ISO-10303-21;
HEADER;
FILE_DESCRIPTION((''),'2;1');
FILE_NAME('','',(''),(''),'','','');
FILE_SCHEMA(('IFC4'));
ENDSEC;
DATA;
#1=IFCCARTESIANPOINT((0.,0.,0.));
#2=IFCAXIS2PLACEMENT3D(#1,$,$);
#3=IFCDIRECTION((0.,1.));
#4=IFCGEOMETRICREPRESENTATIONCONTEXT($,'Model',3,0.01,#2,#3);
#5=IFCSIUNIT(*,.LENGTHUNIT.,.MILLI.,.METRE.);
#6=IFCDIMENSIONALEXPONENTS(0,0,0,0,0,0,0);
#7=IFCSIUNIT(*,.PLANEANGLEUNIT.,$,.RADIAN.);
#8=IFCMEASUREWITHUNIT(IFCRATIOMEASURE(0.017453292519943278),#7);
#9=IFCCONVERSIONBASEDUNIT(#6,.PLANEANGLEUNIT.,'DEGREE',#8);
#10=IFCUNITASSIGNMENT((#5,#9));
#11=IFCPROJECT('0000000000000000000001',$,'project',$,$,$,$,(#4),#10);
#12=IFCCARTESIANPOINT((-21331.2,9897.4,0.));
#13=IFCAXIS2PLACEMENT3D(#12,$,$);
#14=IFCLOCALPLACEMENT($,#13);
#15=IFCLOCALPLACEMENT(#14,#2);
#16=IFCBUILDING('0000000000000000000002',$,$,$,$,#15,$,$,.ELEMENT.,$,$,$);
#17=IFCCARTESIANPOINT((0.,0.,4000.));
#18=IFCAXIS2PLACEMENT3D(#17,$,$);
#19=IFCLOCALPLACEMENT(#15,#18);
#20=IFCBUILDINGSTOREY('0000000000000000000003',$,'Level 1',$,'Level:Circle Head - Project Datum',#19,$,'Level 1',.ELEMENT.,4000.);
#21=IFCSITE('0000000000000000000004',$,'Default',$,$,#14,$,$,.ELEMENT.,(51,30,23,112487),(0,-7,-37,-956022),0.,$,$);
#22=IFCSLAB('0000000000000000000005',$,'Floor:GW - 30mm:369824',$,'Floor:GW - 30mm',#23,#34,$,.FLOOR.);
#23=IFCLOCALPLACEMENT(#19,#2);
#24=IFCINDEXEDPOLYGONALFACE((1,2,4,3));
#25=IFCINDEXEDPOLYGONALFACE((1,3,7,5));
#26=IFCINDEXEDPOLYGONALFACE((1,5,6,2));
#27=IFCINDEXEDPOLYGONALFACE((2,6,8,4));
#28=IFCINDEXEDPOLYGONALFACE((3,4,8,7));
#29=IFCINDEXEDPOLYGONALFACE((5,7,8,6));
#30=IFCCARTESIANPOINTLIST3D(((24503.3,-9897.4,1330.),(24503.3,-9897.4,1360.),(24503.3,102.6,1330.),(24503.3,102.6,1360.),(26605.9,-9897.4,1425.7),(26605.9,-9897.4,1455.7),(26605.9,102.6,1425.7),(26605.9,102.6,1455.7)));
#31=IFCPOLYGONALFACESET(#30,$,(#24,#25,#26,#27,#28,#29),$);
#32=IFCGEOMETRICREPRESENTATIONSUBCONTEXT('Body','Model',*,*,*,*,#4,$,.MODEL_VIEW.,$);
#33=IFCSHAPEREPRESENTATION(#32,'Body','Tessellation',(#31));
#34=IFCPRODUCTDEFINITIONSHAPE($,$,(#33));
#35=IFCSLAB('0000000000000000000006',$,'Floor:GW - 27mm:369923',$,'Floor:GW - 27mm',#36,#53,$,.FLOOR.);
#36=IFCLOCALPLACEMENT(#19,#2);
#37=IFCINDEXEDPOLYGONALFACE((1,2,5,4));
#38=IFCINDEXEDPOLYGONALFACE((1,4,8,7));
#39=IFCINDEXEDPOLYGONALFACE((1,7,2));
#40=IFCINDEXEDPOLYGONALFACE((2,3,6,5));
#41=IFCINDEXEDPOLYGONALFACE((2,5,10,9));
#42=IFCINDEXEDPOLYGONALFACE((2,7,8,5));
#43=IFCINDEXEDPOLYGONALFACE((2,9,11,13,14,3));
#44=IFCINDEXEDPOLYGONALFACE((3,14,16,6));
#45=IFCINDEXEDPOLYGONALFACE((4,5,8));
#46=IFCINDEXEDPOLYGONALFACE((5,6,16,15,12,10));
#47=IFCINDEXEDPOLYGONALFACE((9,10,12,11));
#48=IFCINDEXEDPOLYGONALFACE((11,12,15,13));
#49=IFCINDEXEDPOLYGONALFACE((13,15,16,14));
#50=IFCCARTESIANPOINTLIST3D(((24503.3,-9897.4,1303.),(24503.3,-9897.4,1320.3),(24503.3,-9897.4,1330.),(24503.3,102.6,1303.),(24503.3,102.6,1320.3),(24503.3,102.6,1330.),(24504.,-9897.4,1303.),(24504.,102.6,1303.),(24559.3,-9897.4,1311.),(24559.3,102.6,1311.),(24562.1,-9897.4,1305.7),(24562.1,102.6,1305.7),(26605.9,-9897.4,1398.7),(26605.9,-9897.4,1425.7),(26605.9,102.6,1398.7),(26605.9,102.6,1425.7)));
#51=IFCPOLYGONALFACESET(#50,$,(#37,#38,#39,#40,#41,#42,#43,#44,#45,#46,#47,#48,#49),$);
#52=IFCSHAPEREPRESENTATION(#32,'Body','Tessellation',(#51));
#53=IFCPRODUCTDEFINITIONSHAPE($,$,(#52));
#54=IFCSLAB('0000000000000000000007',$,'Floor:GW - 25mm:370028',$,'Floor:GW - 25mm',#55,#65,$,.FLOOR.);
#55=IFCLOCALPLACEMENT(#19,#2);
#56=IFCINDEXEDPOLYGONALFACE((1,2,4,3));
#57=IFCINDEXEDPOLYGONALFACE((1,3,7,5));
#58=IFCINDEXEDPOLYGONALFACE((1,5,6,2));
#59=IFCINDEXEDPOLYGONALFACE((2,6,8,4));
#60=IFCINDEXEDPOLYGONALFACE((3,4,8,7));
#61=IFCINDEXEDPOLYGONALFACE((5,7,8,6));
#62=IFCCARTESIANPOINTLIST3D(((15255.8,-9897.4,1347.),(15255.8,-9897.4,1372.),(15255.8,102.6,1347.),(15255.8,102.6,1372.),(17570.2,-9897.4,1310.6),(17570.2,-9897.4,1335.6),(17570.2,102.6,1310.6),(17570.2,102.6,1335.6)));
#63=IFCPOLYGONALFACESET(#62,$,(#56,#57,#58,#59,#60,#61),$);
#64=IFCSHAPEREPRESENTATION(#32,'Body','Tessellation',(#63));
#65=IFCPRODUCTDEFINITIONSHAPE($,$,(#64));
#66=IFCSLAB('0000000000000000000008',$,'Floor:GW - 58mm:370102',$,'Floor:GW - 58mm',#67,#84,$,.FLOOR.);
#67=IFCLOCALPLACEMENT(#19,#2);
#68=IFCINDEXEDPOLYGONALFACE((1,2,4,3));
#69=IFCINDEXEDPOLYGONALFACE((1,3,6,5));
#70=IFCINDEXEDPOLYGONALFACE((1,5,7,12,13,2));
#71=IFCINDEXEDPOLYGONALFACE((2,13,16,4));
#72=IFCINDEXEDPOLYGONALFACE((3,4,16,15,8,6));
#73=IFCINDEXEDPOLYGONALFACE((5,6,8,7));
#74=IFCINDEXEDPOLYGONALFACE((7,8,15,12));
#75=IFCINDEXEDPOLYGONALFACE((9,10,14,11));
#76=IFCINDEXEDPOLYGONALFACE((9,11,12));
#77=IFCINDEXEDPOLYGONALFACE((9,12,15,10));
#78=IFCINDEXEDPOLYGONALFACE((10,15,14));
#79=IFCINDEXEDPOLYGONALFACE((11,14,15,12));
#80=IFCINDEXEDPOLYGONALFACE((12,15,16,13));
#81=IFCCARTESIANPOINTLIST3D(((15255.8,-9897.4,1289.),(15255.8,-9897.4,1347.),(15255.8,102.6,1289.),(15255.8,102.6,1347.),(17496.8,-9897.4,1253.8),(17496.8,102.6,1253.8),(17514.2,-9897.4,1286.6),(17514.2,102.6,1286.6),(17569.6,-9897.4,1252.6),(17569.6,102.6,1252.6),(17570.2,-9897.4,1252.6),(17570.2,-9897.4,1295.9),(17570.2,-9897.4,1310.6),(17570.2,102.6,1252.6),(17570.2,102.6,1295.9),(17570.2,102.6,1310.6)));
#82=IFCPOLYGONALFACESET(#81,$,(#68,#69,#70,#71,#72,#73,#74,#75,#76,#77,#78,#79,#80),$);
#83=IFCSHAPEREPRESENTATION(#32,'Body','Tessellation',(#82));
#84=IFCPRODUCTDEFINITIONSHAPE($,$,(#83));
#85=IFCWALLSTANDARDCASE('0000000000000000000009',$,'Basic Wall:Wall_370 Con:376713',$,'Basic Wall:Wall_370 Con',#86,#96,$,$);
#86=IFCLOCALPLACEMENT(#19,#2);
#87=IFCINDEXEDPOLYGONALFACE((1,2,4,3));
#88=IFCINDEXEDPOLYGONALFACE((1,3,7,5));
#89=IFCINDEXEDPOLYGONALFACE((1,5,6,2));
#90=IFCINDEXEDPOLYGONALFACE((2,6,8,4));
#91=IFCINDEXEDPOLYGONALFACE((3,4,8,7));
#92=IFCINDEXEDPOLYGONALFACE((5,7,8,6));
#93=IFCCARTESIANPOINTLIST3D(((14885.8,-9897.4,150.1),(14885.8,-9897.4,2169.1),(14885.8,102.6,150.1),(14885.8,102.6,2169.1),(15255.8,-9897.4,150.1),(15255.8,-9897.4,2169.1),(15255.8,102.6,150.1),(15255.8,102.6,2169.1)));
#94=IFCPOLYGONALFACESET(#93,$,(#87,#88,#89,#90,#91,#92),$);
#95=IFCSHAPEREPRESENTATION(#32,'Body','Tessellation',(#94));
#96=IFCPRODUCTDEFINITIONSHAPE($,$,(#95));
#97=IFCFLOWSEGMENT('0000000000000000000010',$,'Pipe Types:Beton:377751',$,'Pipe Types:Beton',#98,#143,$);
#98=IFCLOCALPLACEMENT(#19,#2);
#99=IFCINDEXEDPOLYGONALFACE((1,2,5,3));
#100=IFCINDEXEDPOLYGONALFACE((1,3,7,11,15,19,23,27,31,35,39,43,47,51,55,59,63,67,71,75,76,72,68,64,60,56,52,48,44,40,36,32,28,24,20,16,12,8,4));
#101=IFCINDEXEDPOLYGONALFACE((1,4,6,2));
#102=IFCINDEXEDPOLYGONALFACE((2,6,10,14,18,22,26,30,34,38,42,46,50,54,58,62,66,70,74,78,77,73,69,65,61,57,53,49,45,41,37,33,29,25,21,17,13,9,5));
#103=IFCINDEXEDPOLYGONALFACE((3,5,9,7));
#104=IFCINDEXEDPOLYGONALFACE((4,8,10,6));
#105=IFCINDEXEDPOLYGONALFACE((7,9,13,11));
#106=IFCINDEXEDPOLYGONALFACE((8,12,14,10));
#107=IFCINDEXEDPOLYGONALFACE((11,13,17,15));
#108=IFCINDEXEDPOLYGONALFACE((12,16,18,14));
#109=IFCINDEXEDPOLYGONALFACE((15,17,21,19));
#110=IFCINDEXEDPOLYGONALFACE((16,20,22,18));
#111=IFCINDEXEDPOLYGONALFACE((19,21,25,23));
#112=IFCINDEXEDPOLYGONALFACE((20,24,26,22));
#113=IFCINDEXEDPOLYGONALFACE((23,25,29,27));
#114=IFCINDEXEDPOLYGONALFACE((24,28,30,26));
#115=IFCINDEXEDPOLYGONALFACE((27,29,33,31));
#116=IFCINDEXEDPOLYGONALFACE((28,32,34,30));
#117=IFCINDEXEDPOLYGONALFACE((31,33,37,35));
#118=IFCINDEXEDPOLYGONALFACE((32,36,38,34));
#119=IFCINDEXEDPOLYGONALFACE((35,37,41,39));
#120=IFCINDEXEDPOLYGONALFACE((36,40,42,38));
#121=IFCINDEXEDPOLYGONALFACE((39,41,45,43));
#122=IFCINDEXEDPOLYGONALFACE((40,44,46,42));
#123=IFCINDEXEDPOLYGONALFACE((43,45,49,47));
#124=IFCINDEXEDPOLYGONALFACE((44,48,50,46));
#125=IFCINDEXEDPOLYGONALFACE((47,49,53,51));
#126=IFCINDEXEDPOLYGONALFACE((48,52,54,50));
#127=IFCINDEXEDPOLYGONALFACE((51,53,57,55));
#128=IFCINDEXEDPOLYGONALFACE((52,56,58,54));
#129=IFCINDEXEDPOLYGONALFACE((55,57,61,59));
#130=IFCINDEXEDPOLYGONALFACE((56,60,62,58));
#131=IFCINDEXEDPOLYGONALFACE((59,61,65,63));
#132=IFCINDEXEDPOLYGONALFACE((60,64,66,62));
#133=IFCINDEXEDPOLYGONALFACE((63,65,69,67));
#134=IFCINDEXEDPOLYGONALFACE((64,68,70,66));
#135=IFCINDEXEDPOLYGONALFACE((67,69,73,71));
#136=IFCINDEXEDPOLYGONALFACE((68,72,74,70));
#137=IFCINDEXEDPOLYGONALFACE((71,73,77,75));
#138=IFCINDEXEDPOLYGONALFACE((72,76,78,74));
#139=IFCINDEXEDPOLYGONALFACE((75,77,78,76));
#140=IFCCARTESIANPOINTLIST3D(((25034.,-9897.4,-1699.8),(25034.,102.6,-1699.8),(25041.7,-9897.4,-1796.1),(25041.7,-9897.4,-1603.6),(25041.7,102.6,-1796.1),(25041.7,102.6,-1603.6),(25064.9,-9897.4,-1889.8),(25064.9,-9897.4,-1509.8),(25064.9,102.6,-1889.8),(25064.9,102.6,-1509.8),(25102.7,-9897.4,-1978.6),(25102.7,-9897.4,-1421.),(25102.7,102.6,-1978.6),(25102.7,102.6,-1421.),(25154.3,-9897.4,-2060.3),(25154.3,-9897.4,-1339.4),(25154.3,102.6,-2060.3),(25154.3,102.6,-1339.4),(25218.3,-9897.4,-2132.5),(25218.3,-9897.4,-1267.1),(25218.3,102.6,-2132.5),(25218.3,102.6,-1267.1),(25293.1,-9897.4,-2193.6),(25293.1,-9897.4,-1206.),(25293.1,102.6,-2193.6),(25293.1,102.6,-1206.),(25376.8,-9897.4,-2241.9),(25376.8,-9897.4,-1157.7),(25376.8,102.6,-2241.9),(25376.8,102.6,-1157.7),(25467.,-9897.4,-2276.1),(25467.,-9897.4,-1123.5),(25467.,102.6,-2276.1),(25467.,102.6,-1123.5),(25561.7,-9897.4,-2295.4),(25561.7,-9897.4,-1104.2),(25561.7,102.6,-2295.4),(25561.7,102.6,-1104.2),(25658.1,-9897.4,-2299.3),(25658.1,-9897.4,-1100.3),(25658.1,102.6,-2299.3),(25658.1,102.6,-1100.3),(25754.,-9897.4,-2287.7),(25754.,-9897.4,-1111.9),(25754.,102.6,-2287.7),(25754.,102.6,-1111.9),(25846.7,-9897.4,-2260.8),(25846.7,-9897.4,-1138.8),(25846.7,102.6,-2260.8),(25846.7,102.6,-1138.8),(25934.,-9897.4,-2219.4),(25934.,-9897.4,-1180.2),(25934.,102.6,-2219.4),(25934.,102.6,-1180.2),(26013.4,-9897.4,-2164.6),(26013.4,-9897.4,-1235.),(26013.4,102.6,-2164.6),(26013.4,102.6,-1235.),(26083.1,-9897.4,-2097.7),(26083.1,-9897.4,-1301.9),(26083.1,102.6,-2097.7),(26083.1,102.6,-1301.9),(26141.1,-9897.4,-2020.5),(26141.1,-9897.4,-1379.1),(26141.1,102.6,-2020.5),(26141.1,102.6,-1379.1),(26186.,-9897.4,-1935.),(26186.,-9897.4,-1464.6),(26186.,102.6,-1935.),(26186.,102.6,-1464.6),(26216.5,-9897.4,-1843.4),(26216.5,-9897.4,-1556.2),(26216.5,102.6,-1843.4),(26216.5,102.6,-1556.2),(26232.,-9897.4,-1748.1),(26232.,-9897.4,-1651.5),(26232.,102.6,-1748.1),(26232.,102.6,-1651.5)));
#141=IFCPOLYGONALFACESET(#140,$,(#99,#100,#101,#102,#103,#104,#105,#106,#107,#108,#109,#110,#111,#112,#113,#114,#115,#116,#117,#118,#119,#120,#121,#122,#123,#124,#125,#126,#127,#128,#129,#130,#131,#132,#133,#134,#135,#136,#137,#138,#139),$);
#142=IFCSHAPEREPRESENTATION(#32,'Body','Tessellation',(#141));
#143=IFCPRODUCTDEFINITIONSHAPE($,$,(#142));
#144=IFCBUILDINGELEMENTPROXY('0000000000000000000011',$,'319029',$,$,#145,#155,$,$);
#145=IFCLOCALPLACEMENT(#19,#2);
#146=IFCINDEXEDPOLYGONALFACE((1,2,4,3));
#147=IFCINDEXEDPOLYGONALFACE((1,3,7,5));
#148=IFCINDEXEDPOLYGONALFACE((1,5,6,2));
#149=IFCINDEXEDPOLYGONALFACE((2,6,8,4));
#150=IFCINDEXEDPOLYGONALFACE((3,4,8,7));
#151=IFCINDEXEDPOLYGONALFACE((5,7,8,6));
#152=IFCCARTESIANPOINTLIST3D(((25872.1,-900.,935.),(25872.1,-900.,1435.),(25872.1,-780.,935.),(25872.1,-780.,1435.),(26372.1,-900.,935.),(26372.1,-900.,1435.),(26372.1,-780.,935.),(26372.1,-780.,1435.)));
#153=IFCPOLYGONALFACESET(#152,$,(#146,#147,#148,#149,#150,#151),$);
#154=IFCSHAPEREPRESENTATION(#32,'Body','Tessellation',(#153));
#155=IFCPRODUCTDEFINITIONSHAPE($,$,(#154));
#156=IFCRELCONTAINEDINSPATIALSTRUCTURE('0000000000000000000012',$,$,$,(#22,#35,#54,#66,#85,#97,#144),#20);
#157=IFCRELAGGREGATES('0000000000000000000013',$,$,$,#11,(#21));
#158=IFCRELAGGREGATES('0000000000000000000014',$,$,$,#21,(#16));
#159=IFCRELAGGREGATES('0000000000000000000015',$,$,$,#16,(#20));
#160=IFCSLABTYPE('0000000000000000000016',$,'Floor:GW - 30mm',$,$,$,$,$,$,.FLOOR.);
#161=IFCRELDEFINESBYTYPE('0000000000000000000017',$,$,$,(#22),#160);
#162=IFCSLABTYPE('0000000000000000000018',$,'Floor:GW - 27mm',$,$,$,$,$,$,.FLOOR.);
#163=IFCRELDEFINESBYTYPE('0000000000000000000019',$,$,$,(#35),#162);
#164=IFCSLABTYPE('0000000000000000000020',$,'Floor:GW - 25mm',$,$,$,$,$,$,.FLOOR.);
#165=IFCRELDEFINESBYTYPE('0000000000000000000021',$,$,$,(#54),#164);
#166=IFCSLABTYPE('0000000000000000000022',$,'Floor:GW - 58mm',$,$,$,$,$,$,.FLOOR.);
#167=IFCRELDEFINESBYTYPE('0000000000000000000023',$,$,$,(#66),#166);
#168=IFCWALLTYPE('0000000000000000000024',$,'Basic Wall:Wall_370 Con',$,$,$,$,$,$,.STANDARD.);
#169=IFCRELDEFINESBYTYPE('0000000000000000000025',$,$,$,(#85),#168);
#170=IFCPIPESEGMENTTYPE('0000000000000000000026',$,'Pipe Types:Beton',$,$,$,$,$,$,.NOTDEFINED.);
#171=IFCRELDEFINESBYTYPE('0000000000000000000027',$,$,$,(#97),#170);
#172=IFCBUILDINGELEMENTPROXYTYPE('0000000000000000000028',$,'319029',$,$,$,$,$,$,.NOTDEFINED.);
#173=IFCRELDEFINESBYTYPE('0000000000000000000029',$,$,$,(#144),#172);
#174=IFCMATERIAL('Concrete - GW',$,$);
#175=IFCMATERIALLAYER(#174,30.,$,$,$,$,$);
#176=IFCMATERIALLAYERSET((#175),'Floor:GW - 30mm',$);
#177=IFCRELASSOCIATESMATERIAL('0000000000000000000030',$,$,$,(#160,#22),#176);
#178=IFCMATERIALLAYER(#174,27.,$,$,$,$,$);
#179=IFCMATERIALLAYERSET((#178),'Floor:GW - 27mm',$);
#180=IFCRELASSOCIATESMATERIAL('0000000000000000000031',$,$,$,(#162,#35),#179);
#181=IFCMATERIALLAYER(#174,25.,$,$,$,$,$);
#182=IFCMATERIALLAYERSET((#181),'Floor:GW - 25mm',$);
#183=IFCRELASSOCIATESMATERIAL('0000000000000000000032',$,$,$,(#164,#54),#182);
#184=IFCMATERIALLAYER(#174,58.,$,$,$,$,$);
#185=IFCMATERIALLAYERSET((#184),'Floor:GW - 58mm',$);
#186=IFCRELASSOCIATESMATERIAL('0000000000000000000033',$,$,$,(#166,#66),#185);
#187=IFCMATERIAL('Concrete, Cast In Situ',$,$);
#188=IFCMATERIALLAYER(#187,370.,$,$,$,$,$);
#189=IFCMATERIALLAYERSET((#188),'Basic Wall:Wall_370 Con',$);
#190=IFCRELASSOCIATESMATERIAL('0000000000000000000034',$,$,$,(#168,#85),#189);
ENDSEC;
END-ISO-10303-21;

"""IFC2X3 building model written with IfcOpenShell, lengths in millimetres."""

from ifc_helpers import new_model, entity, si_unit, converted_unit, direction, frame, frame_2d, origin, origin_2d_with_axis, place, context, subcontext, project, spatial, polyline, rectangle, circle, extrude, clip, halfspace, bounded_halfspace, material, layer, layer_set, layer_usage, type_object, element, save


model = new_model("IFC2X3")

# Units and contexts
model_context = context("Model", 3, precision=0.01, world=origin(), true_north=direction((0.0, 1.0)))
body_context = subcontext(model_context, "Body", "Model", "MODEL_VIEW")
ifc_project = project(units=[si_unit("LENGTHUNIT", "METRE", prefix="MILLI"), converted_unit("PLANEANGLEUNIT", "DEGREE", entity("IfcRatioMeasure", 0.017453292519943278), si_unit("PLANEANGLEUNIT", "RADIAN"), dimensions=[0, 0, 0, 0, 0, 0, 0])], contexts=[model_context])

# Site, building, storey
site_placement = place(None, frame((-21331.2, 9897.4, 0.0)))
site = spatial("IfcSite", under=ifc_project, at=site_placement, Name="Default", CompositionType="ELEMENT", RefLatitude=(51, 30, 23, 112487), RefLongitude=(0, -7, -37, -956022), RefElevation=0.0)
building_placement = place(site_placement, origin())
building = spatial("IfcBuilding", under=site, at=building_placement, CompositionType="ELEMENT")
storey_placement = place(building_placement, frame((0.0, 0.0, 4000.0)))
storey = spatial("IfcBuildingStorey", under=building, at=storey_placement, Name="Level 1", ObjectType="Level:Circle Head - Project Datum", LongName="Level 1", CompositionType="ELEMENT", Elevation=4000.0)

# Slabs
ifc_material_1 = material(Name="Concrete - GW")
ifc_layer_1 = layer(ifc_material_1, 30.0)
ifc_layer_set_1 = layer_set([ifc_layer_1], Name="Floor:GW - 30mm")
ifc_layer_usage_1 = layer_usage(ifc_layer_set_1, "AXIS3", "POSITIVE", 0.0)
slab_type_1 = type_object("IfcSlabType", Name="Floor:GW - 30mm", PredefinedType="FLOOR", material=ifc_layer_set_1)
slab_1_placement = place(storey_placement, origin())
element("IfcSlab", 1, at=slab_1_placement, inside=storey, type_object=slab_type_1, material=ifc_layer_usage_1, Name="Floor:GW - 30mm:369824", ObjectType="Floor:GW - 30mm", PredefinedType="FLOOR", context=body_context, shape_type="SweptSolid", body=[
    clip(clip(extrude(rectangle(XDim=2104.9, YDim=10000.0, at=frame_2d((0.0, 0.0), x_axis=(0.0, 1.0))), frame((25554.6, -4897.4, 1407.8), z_axis=(0.045468, 0.0, -0.998966), x_axis=(0.0, 1.0, 0.0)), (0.0, -0.045468, 0.998966), 30.0), halfspace(frame((25554.6, -4897.4, 1377.8), z_axis=(0.045468, 0.0, -0.998966), x_axis=(-0.998966, 0.0, -0.045468)), False)), halfspace(frame((25554.6, -4897.4, 1407.8), z_axis=(-0.045468, 0.0, 0.998966), x_axis=(-0.998966, 0.0, -0.045468)), False)),
])
ifc_layer_2 = layer(ifc_material_1, 27.0)
ifc_layer_set_2 = layer_set([ifc_layer_2], Name="Floor:GW - 27mm")
ifc_layer_usage_2 = layer_usage(ifc_layer_set_2, "AXIS3", "POSITIVE", 0.0)
slab_type_2 = type_object("IfcSlabType", Name="Floor:GW - 27mm", PredefinedType="FLOOR", material=ifc_layer_set_2)
slab_2_placement = place(storey_placement, origin())
element("IfcSlab", 2, at=slab_2_placement, inside=storey, type_object=slab_type_2, material=ifc_layer_usage_2, Name="Floor:GW - 27mm:369923", ObjectType="Floor:GW - 27mm", PredefinedType="FLOOR", context=body_context, shape_type="SweptSolid", body=[
    clip(clip(clip(clip(extrude(rectangle(XDim=2104.9, YDim=10000.0, at=frame_2d((0.0, 0.0), x_axis=(0.0, 1.0))), frame((25554.6, -4897.4, 1377.8), z_axis=(0.045468, 0.0, -0.998966), x_axis=(0.0, 1.0, 0.0)), (0.0, -0.045468, 0.998966), 27.0), halfspace(frame((25554.6, -4897.4, 1350.8), z_axis=(0.045468, 0.0, -0.998966), x_axis=(0.998966, 0.0, 0.045468)), False)), halfspace(frame((25554.6, -4897.4, 1377.8), z_axis=(-0.045468, 0.0, 0.998966), x_axis=(0.998966, 0.0, 0.045468)), False)), bounded_halfspace(frame((24559.3, -10822.9, 1311.0), z_axis=(-0.164399, 0.0, -0.986394), x_axis=(0.0, 1.0, 0.0)), False, frame((25554.6, -4897.4, 1377.8), z_axis=(0.045468, 0.0, -0.998966), x_axis=(0.0, 1.0, 0.0)), polyline([(5000.0, -997.4), (-5000.0, -997.4), (-5000.0, -1052.9), (5000.0, -1052.9), (5000.0, -997.4)]))), bounded_halfspace(frame((24703.3, -10822.9, 1040.0), z_axis=(-0.883074, 0.0, -0.469235), x_axis=(0.0, 1.0, 0.0)), False, frame((25554.6, -4897.4, 1377.8), z_axis=(0.045468, 0.0, -0.998966), x_axis=(0.0, 1.0, 0.0)), polyline([(-5000.0, -997.4), (5000.0, -997.4), (5000.0, -994.8), (-5000.0, -994.8), (-5000.0, -997.4)]))),
])
ifc_layer_3 = layer(ifc_material_1, 25.0)
ifc_layer_set_3 = layer_set([ifc_layer_3], Name="Floor:GW - 25mm")
ifc_layer_usage_3 = layer_usage(ifc_layer_set_3, "AXIS3", "POSITIVE", 0.0)
slab_type_3 = type_object("IfcSlabType", Name="Floor:GW - 25mm", PredefinedType="FLOOR", material=ifc_layer_set_3)
slab_3_placement = place(storey_placement, origin())
element("IfcSlab", 3, at=slab_3_placement, inside=storey, type_object=slab_type_3, material=ifc_layer_usage_3, Name="Floor:GW - 25mm:370028", ObjectType="Floor:GW - 25mm", PredefinedType="FLOOR", context=body_context, shape_type="SweptSolid", body=[
    clip(clip(extrude(rectangle(XDim=2314.8, YDim=10000.0, at=frame_2d((0.0, 0.0), x_axis=(0.0, 1.0))), frame((16413.0, -4897.4, 1353.8), z_axis=(-0.01573, 0.0, -0.999876), x_axis=(0.0, 1.0, 0.0)), (0.0, 0.01573, 0.999876), 25.0), halfspace(frame((16413.0, -4897.4, 1328.8), z_axis=(-0.01573, 0.0, -0.999876), x_axis=(0.0, -1.0, 0.0)), False)), halfspace(frame((16413.0, -4897.4, 1353.8), z_axis=(0.01573, 0.0, 0.999876), x_axis=(0.0, -1.0, 0.0)), False)),
])
ifc_layer_4 = layer(ifc_material_1, 58.0)
ifc_layer_set_4 = layer_set([ifc_layer_4], Name="Floor:GW - 58mm")
ifc_layer_usage_4 = layer_usage(ifc_layer_set_4, "AXIS3", "POSITIVE", 0.0)
slab_type_4 = type_object("IfcSlabType", Name="Floor:GW - 58mm", PredefinedType="FLOOR", material=ifc_layer_set_4)
slab_4_placement = place(storey_placement, origin())
element("IfcSlab", 4, at=slab_4_placement, inside=storey, type_object=slab_type_4, material=ifc_layer_usage_4, Name="Floor:GW - 58mm:370102", ObjectType="Floor:GW - 58mm", PredefinedType="FLOOR", context=body_context, shape_type="SweptSolid", body=[
    clip(clip(clip(clip(extrude(rectangle(XDim=2314.8, YDim=10000.0, at=frame_2d((0.0, 0.0), x_axis=(0.0, 1.0))), frame((16413.0, -4897.4, 1328.8), z_axis=(-0.01573, 0.0, -0.999876), x_axis=(0.0, 1.0, 0.0)), (0.0, 0.01573, 0.999876), 58.0), halfspace(frame((16413.0, -4897.4, 1270.8), z_axis=(-0.01573, 0.0, -0.999876), x_axis=(0.0, -1.0, 0.0)), False)), halfspace(frame((16413.0, -4897.4, 1328.8), z_axis=(0.01573, 0.0, 0.999876), x_axis=(0.0, -1.0, 0.0)), False)), bounded_halfspace(frame((17574.4, -10447.5, 1296.6), z_axis=(0.164399, 0.0, -0.986394), x_axis=(0.0, 1.0, 0.0)), False, frame((16413.0, -4897.4, 1328.8), z_axis=(-0.01573, 0.0, -0.999876), x_axis=(0.0, 1.0, 0.0)), polyline([(-5000.0, 1101.8), (5000.0, 1101.8), (5000.0, 1157.6), (-5000.0, 1157.6), (-5000.0, 1101.8)]))), bounded_halfspace(frame((17514.2, -10447.5, 1286.6), z_axis=(0.883074, 0.0, -0.469235), x_axis=(0.0, 1.0, 0.0)), False, frame((16413.0, -4897.4, 1328.8), z_axis=(-0.01573, 0.0, -0.999876), x_axis=(0.0, 1.0, 0.0)), polyline([(5000.0, 1101.8), (-5000.0, 1101.8), (-5000.0, 1084.8), (5000.0, 1084.8), (5000.0, 1101.8)]))),
])

# Wall
ifc_material_2 = material(Name="Concrete, Cast In Situ")
ifc_layer_5 = layer(ifc_material_2, 370.0)
ifc_layer_set_5 = layer_set([ifc_layer_5], Name="Basic Wall:Wall_370 Con")
ifc_layer_usage_5 = layer_usage(ifc_layer_set_5, "AXIS2", "NEGATIVE", 185.0)
wall_type = type_object("IfcWallType", Name="Basic Wall:Wall_370 Con", PredefinedType="STANDARD", material=ifc_layer_set_5)
wall_placement = place(storey_placement, frame((15070.8, -9897.4, 150.1), z_axis=(0.0, 0.0, 1.0), x_axis=(0.0, 1.0, 0.0)))
element("IfcWallStandardCase", 5, at=wall_placement, inside=storey, type_object=wall_type, material=ifc_layer_usage_5, Name="Basic Wall:Wall_370 Con:376713", ObjectType="Basic Wall:Wall_370 Con", context=body_context, shape_type="SweptSolid", body=[
    extrude(rectangle(XDim=10000.0, YDim=370.0, at=frame_2d((5000.0, 0.0), x_axis=(-1.0, 0.0))), origin(), (0.0, 0.0, 1.0), 2019.0),
])

# Flow segment
pipe_segment_type = type_object("IfcPipeSegmentType", Name="Pipe Types:Beton", PredefinedType="NOTDEFINED")
flow_segment_placement = place(storey_placement, origin())
element("IfcFlowSegment", 6, at=flow_segment_placement, inside=storey, type_object=pipe_segment_type, Name="Pipe Types:Beton:377751", ObjectType="Pipe Types:Beton", context=body_context, shape_type="SweptSolid", body=[
    extrude(circle(Radius=600.0, at=frame_2d((0.0, 0.0), x_axis=(1.0, 0.0))), frame((25634.0, -9897.4, -1699.8), z_axis=(0.0, 1.0, 0.0), x_axis=(-1.0, 0.0, 0.0)), (0.0, 0.0, 1.0), 10000.0),
])

# Building element proxy
building_element_proxy_type_1 = type_object("IfcBuildingElementProxyType", Name="319029", PredefinedType="NOTDEFINED")
proxy_1_placement = place(storey_placement, origin())
element("IfcBuildingElementProxy", 7, at=proxy_1_placement, inside=storey, type_object=building_element_proxy_type_1, Name="319029", context=body_context, shape_type="SweptSolid", body=[
    extrude(rectangle(XDim=500.0, YDim=120.0, at=origin_2d_with_axis()), frame((26122.1, -840.0, 935.0), z_axis=(0.0, 0.0, 1.0), x_axis=(-1.0, 0.0, 0.0)), (0.0, 0.0, 1.0), 500.0),
])

save(model, "model.ifc")
